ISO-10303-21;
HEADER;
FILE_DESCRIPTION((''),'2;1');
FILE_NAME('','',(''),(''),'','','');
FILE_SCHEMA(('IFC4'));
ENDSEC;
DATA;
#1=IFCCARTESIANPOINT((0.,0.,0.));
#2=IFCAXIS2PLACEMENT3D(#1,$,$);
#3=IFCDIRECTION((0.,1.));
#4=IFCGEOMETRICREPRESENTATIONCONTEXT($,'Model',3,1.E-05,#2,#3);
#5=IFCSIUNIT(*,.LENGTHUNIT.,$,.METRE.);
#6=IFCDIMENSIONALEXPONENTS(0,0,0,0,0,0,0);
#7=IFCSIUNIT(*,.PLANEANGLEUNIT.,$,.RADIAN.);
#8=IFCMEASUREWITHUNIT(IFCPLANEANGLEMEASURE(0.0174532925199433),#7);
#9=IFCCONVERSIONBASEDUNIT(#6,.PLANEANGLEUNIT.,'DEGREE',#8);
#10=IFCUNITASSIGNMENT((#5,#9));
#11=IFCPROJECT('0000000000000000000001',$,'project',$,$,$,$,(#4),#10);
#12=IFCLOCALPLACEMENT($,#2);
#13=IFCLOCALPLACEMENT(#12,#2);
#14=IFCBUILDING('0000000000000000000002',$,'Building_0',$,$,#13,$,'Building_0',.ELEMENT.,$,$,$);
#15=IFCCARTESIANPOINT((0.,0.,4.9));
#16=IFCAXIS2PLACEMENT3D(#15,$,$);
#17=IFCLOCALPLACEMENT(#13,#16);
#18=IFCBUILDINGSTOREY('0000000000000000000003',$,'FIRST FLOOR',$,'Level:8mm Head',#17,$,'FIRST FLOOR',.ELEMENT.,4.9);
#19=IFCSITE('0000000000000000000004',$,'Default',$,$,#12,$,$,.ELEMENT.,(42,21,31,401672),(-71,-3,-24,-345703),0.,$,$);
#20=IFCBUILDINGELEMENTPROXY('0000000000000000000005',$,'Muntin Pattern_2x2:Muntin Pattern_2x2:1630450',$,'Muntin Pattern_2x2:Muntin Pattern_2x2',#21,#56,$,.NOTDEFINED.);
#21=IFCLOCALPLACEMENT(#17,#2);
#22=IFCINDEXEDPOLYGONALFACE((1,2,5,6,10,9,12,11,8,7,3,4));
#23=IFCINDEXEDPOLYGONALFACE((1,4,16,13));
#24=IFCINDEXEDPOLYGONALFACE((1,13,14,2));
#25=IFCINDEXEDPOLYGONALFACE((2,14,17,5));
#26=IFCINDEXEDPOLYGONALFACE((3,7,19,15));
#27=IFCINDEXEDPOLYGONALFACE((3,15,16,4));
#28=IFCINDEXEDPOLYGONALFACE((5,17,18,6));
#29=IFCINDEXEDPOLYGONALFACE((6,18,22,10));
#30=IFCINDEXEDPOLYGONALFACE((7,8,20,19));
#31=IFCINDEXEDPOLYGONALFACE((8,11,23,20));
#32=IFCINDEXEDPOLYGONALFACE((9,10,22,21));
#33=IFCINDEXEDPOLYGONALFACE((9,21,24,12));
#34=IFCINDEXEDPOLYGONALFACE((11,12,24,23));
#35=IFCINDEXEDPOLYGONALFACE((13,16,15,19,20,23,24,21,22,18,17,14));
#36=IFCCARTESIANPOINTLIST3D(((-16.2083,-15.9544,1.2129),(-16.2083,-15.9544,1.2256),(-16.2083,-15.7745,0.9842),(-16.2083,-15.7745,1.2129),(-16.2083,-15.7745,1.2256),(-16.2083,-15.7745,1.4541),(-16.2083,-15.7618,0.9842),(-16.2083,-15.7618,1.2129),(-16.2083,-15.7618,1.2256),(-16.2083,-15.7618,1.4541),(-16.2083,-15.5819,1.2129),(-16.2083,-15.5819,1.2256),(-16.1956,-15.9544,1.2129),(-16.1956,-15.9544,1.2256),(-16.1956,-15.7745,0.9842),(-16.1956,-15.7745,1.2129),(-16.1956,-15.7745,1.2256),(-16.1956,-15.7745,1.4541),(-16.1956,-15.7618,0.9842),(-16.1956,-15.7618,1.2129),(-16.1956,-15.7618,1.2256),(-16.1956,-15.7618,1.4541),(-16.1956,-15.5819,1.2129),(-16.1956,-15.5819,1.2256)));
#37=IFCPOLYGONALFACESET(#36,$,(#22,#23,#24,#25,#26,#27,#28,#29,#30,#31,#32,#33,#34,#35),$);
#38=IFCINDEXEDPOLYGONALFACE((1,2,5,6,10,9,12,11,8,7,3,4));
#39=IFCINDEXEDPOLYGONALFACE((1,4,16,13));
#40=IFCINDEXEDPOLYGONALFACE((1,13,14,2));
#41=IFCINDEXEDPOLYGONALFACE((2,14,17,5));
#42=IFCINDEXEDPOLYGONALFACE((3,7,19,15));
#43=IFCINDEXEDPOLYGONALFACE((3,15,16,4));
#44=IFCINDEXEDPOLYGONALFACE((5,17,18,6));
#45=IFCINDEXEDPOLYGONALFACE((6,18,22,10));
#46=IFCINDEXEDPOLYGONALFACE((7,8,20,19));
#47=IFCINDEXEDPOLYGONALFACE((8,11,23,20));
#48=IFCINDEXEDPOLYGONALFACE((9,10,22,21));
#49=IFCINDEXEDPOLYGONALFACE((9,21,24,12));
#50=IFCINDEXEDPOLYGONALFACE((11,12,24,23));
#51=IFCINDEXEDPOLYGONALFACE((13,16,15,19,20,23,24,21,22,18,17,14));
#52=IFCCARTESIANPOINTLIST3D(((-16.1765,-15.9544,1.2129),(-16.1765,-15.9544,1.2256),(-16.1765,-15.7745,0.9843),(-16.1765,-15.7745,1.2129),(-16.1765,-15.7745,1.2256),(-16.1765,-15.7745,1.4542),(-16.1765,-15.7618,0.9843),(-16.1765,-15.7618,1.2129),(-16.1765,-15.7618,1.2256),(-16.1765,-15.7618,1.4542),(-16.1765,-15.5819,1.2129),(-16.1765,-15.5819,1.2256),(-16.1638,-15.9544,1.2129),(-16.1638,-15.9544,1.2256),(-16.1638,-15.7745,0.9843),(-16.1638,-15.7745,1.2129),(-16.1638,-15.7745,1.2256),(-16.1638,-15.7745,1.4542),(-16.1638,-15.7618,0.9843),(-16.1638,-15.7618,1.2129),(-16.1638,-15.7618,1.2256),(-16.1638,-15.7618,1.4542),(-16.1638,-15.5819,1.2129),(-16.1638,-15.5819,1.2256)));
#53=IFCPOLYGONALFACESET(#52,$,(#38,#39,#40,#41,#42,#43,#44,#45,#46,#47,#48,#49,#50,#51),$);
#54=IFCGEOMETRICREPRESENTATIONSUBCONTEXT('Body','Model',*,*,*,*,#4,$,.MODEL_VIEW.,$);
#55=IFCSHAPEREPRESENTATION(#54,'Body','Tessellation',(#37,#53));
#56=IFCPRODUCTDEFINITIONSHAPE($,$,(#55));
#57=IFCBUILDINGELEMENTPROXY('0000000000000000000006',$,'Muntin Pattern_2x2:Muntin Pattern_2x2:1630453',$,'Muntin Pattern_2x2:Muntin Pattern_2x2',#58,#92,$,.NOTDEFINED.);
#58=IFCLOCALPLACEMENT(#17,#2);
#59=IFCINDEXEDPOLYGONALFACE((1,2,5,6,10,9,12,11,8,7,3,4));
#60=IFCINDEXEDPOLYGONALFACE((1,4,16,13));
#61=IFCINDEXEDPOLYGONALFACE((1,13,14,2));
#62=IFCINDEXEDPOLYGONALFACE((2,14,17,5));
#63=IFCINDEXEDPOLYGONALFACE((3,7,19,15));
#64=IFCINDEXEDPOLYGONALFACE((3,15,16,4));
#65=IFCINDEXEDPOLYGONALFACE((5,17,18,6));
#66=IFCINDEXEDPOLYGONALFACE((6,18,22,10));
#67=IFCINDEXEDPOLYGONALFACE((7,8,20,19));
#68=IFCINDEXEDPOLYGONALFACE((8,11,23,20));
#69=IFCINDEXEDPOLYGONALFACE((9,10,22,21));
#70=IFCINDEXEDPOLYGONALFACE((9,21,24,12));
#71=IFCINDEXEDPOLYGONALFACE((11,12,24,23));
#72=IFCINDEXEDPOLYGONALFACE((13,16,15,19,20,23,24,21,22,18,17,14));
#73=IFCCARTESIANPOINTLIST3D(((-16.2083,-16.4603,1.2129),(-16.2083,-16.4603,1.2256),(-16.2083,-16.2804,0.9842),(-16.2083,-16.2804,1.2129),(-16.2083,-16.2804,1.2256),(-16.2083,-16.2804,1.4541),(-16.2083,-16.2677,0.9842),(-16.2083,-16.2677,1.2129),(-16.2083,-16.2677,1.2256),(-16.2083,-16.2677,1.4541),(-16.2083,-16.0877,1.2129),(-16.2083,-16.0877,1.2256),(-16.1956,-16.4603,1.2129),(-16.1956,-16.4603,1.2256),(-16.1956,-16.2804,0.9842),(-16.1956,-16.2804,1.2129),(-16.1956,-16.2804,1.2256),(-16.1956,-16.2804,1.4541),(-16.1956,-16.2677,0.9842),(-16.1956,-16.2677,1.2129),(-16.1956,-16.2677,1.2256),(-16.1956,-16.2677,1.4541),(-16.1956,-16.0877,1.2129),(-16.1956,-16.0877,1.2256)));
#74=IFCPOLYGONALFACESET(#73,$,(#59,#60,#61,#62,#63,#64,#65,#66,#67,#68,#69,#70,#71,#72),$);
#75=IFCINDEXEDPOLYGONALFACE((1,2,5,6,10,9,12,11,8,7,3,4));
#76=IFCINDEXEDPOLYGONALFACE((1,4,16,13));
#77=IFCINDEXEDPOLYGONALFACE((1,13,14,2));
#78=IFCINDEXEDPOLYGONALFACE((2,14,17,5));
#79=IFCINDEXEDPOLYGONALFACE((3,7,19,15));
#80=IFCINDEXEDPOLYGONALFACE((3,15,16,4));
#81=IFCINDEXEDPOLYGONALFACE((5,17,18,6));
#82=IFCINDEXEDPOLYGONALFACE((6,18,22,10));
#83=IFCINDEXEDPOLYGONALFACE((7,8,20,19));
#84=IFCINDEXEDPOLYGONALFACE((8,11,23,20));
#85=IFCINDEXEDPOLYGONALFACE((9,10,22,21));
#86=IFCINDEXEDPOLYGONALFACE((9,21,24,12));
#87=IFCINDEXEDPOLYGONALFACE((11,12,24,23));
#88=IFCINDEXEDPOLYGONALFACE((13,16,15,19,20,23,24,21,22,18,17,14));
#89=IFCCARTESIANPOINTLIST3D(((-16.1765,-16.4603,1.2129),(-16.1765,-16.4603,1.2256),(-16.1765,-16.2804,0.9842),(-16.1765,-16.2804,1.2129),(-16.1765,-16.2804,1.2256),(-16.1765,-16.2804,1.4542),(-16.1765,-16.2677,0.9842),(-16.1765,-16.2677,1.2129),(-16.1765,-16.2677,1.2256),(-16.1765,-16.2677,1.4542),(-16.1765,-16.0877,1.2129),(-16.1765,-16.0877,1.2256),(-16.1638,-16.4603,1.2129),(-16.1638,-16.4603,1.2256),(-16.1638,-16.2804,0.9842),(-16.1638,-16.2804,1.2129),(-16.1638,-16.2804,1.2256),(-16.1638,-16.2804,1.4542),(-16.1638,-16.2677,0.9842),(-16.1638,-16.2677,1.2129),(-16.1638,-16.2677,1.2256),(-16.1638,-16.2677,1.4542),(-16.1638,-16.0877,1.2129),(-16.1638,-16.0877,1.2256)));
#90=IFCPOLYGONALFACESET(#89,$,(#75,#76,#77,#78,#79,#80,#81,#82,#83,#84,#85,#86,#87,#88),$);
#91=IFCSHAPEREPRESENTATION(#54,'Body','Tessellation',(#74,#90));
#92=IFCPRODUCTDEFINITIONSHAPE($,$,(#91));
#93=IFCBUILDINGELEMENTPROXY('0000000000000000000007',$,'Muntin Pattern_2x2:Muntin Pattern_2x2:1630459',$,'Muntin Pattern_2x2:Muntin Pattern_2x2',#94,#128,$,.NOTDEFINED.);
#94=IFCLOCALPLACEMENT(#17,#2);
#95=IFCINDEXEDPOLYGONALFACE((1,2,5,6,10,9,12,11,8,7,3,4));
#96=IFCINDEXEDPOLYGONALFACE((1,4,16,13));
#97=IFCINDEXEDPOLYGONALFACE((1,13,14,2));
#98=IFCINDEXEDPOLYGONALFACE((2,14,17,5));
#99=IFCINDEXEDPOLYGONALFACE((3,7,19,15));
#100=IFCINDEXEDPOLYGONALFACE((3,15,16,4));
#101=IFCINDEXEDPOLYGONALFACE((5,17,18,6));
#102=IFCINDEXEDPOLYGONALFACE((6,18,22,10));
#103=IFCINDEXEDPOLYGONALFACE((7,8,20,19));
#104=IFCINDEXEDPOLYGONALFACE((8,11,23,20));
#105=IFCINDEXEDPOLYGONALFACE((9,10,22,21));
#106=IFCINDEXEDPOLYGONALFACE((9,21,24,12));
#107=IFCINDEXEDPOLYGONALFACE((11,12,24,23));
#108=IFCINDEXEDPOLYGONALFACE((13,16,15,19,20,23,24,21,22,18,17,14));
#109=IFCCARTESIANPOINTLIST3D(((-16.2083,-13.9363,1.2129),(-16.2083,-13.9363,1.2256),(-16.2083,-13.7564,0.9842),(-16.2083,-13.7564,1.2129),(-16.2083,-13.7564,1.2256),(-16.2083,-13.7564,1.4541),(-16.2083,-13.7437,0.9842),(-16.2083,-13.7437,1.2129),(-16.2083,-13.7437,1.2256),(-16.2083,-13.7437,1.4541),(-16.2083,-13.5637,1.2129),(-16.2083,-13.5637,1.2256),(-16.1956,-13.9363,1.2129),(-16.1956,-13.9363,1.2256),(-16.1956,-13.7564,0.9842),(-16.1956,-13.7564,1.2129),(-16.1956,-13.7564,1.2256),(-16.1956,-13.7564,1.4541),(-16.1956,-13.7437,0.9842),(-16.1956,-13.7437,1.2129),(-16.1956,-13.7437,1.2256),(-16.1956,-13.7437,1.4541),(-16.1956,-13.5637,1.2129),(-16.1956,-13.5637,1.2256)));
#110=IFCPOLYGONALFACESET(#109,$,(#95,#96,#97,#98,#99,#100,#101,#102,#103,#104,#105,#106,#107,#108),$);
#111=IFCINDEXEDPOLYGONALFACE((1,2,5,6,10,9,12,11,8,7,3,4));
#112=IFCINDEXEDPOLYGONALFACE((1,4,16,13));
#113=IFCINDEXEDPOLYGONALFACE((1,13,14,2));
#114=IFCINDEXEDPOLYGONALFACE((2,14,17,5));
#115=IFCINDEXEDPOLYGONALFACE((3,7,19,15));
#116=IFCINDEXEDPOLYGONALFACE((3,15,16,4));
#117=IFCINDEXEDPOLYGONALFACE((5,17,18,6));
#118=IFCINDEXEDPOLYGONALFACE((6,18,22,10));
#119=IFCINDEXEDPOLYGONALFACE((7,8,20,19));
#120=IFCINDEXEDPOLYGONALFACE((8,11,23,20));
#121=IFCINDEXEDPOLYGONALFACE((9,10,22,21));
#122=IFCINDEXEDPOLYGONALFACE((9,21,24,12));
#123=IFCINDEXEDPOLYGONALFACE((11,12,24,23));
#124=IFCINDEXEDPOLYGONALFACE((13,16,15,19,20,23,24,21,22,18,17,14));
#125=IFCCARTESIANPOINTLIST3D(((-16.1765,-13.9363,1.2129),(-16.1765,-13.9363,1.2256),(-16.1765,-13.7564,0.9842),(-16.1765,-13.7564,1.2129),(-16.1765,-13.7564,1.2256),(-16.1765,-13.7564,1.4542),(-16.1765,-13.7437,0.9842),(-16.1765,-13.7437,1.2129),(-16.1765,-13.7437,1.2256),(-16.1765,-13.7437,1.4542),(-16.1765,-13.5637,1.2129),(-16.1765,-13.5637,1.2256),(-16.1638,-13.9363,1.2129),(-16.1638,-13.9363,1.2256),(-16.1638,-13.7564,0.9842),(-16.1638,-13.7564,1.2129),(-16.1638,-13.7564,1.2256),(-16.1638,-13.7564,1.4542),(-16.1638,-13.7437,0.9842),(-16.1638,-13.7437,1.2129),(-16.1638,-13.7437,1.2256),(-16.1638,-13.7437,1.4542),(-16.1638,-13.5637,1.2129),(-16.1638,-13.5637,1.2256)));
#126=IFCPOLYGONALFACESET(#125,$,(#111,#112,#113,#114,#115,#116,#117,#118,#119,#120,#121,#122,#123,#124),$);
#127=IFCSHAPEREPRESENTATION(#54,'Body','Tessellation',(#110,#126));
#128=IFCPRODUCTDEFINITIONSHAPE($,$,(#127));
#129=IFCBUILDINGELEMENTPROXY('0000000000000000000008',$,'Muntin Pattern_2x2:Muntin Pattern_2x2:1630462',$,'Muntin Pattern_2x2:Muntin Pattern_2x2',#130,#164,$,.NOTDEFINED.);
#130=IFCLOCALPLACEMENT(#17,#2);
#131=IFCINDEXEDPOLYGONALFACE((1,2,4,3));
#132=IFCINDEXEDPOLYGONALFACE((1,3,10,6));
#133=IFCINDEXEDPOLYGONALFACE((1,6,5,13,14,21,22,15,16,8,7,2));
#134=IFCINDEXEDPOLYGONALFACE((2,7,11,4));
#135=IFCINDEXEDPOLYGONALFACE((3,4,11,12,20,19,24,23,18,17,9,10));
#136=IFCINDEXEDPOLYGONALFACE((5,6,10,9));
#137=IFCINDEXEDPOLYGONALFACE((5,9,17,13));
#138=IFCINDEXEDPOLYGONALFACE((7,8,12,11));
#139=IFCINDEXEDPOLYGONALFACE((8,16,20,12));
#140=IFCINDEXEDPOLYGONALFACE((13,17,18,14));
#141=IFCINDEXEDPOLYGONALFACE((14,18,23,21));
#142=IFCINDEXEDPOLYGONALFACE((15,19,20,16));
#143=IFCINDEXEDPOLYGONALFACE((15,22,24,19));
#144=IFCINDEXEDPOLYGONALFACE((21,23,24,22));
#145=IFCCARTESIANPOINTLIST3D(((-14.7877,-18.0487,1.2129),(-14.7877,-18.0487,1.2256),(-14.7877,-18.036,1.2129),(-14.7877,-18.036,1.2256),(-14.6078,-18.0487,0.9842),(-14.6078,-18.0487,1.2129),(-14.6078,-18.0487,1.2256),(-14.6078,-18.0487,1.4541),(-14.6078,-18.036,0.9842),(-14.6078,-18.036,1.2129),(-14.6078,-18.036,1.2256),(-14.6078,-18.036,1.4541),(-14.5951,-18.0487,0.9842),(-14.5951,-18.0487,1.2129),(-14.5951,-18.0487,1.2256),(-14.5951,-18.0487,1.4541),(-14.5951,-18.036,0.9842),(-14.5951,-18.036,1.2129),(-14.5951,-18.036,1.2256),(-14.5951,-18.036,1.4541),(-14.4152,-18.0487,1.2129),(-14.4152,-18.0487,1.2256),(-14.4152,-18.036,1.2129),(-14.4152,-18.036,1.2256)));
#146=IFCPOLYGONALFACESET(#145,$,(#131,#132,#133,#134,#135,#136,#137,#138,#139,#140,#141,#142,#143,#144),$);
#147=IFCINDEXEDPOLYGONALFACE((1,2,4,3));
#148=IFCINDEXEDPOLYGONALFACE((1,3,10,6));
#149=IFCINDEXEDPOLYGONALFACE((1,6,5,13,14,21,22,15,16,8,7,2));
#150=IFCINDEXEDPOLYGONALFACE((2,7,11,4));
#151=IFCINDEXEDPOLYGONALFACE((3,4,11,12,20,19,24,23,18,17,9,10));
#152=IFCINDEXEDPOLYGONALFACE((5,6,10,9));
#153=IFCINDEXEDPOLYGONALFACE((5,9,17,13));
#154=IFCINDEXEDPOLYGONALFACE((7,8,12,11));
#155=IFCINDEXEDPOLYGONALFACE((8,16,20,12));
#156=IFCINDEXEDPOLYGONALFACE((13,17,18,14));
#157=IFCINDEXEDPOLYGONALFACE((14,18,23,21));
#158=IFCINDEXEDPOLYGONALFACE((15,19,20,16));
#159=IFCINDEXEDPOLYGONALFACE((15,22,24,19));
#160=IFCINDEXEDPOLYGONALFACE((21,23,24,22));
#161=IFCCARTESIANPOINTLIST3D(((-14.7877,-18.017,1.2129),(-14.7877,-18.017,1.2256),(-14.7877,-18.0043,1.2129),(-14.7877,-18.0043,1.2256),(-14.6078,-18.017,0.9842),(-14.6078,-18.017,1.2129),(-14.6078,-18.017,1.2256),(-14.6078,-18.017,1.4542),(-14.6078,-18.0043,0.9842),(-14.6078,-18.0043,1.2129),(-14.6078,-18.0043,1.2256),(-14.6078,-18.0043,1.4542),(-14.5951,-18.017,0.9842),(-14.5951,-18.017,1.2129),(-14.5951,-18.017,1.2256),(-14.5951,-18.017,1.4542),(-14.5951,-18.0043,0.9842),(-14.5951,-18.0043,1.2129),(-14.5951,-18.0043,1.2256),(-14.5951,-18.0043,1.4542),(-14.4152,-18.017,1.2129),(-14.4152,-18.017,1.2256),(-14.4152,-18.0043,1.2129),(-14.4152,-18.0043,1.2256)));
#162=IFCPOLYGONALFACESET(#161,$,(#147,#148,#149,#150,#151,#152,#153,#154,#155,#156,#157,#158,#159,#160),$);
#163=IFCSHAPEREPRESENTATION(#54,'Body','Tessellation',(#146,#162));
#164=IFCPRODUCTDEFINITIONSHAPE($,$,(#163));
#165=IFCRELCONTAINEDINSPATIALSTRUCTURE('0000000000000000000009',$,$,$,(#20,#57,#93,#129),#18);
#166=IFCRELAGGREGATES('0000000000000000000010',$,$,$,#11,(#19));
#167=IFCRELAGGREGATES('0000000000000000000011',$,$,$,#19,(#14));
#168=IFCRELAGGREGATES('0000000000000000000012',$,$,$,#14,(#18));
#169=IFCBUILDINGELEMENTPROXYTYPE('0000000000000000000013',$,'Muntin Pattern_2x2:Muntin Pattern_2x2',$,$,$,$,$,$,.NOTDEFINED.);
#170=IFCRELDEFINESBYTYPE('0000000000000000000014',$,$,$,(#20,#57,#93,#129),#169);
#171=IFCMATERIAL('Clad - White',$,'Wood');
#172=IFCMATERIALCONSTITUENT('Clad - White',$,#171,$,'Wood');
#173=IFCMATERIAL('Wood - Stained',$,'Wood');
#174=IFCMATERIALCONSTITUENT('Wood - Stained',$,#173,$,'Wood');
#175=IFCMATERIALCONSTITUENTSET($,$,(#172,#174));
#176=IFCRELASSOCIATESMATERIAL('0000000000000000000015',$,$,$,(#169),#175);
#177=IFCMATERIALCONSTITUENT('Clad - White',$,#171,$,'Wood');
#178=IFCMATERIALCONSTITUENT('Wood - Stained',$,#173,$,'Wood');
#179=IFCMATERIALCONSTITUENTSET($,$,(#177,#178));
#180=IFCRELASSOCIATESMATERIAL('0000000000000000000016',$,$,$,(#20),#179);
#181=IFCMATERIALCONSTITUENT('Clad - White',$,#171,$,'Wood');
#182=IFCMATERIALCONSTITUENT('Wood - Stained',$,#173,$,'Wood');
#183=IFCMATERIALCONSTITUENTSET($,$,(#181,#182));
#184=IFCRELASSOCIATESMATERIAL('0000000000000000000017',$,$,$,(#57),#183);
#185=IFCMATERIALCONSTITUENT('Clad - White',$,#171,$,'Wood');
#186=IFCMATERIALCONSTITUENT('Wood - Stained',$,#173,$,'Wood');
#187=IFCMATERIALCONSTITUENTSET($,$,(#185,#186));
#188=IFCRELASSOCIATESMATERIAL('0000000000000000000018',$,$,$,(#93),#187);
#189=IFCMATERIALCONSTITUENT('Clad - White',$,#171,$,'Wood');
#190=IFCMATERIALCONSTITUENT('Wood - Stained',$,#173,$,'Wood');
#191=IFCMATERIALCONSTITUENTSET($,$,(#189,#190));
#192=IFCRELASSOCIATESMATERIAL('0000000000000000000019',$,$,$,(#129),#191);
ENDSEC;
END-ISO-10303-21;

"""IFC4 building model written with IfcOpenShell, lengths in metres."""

from ifc_helpers import new_model, entity, si_unit, converted_unit, direction, frame, origin, place, context, subcontext, project, spatial, indexed_curve, outline, extrude, source, transform, mapped, material, constituent, constituent_set, type_object, type_shapes, element, save


model = new_model("IFC4")

# Units and contexts
model_context = context("Model", 3, precision=1e-05, world=origin(), true_north=direction((0.0, 1.0)))
body_context = subcontext(model_context, "Body", "Model", "MODEL_VIEW")
ifc_project = project(units=[si_unit("LENGTHUNIT", "METRE"), converted_unit("PLANEANGLEUNIT", "DEGREE", entity("IfcPlaneAngleMeasure", 0.0174532925199433), si_unit("PLANEANGLEUNIT", "RADIAN"), dimensions=[0, 0, 0, 0, 0, 0, 0])], contexts=[model_context])

# Site, building, storey
site_placement = place(None, origin())
site = spatial("IfcSite", under=ifc_project, at=site_placement, Name="Default", CompositionType="ELEMENT", RefLatitude=(42, 21, 31, 401672), RefLongitude=(-71, -3, -24, -345703), RefElevation=0.0)
building_placement = place(site_placement, origin())
building = spatial("IfcBuilding", under=site, at=building_placement, Name="Building_0", LongName="Building_0", CompositionType="ELEMENT")
storey_placement = place(building_placement, frame((0.0, 0.0, 4.9)))
storey = spatial("IfcBuildingStorey", under=building, at=storey_placement, Name="FIRST FLOOR", ObjectType="Level:8mm Head", LongName="FIRST FLOOR", CompositionType="ELEMENT", Elevation=4.9)

# Shared definitions
ifc_material_1 = material(Name="Clad - White", Category="Wood")

# Building element proxies
ifc_material_2 = material(Name="Wood - Stained", Category="Wood")
ifc_constituent_1 = constituent(ifc_material_1, Name="Clad - White", Category="Wood")
ifc_constituent_2 = constituent(ifc_material_2, Name="Wood - Stained", Category="Wood")
ifc_constituent_set_1 = constituent_set(constituents=[ifc_constituent_1, ifc_constituent_2])
ifc_constituent_3 = constituent(ifc_material_1, Name="Clad - White", Category="Wood")
ifc_constituent_4 = constituent(ifc_material_2, Name="Wood - Stained", Category="Wood")
ifc_constituent_set_2 = constituent_set(constituents=[ifc_constituent_3, ifc_constituent_4])
building_element_proxy_type_1 = type_object("IfcBuildingElementProxyType", Name="Muntin Pattern_2x2:Muntin Pattern_2x2", PredefinedType="NOTDEFINED", material=ifc_constituent_set_2)
shared_shape_1 = source(origin(), body_context, "Body", "SweptSolid", [
    extrude(outline(indexed_curve([(0.0064, -0.0064), (0.2349, -0.0064), (0.2349, 0.0063), (0.0064, 0.0063), (0.0064, 0.1863), (-0.0063, 0.1863), (-0.0063, 0.0063), (-0.235, 0.0063), (-0.235, -0.0064), (-0.0063, -0.0064), (-0.0063, -0.1863), (0.0064, -0.1863), (0.0064, -0.0064)], self_intersect=False)), frame((0.0, -0.0222, 0.2349), z_axis=(0.0, 1.0, 0.0), x_axis=(0.0, 0.0, 1.0)), (0.0, 0.0, 1.0), 0.0127),
    extrude(outline(indexed_curve([(0.0064, -0.0064), (0.235, -0.0064), (0.235, 0.0063), (0.0064, 0.0063), (0.0064, 0.1863), (-0.0063, 0.1863), (-0.0063, 0.0063), (-0.235, 0.0063), (-0.235, -0.0064), (-0.0063, -0.0064), (-0.0063, -0.1863), (0.0064, -0.1863), (0.0064, -0.0064)], self_intersect=False)), frame((0.0, 0.0095, 0.235), z_axis=(0.0, 1.0, 0.0), x_axis=(0.0, 0.0, 1.0)), (0.0, 0.0, 1.0), 0.0127),
])
type_shapes(building_element_proxy_type_1, [shared_shape_1])
proxy_1_placement = place(storey_placement, frame((-16.1861, -15.7681, 0.9843), z_axis=(0.0, 0.0, 1.0), x_axis=(0.0, -1.0, 0.0)))
element("IfcBuildingElementProxy", 1, at=proxy_1_placement, inside=storey, type_object=building_element_proxy_type_1, material=ifc_constituent_set_1, Name="Muntin Pattern_2x2:Muntin Pattern_2x2:1630450", ObjectType="Muntin Pattern_2x2:Muntin Pattern_2x2", PredefinedType="NOTDEFINED", context=body_context, shape_type="MappedRepresentation", body=[
    mapped(shared_shape_1, transform((0.0, 0.0, 0.0), scale=1.0)),
])
ifc_constituent_5 = constituent(ifc_material_1, Name="Clad - White", Category="Wood")
ifc_constituent_6 = constituent(ifc_material_2, Name="Wood - Stained", Category="Wood")
ifc_constituent_set_3 = constituent_set(constituents=[ifc_constituent_5, ifc_constituent_6])
proxy_2_placement = place(storey_placement, frame((-16.1861, -16.274, 0.9842), z_axis=(0.0, 0.0, 1.0), x_axis=(0.0, -1.0, 0.0)))
element("IfcBuildingElementProxy", 2, at=proxy_2_placement, inside=storey, type_object=building_element_proxy_type_1, material=ifc_constituent_set_3, Name="Muntin Pattern_2x2:Muntin Pattern_2x2:1630453", ObjectType="Muntin Pattern_2x2:Muntin Pattern_2x2", PredefinedType="NOTDEFINED", context=body_context, shape_type="MappedRepresentation", body=[
    mapped(shared_shape_1, transform((0.0, 0.0, 0.0), scale=1.0)),
])
ifc_constituent_7 = constituent(ifc_material_1, Name="Clad - White", Category="Wood")
ifc_constituent_8 = constituent(ifc_material_2, Name="Wood - Stained", Category="Wood")
ifc_constituent_set_4 = constituent_set(constituents=[ifc_constituent_7, ifc_constituent_8])
proxy_3_placement = place(storey_placement, frame((-16.1861, -13.75, 0.9842), z_axis=(0.0, 0.0, 1.0), x_axis=(0.0, -1.0, 0.0)))
element("IfcBuildingElementProxy", 3, at=proxy_3_placement, inside=storey, type_object=building_element_proxy_type_1, material=ifc_constituent_set_4, Name="Muntin Pattern_2x2:Muntin Pattern_2x2:1630459", ObjectType="Muntin Pattern_2x2:Muntin Pattern_2x2", PredefinedType="NOTDEFINED", context=body_context, shape_type="MappedRepresentation", body=[
    mapped(shared_shape_1, transform((0.0, 0.0, 0.0), scale=1.0)),
])
ifc_constituent_9 = constituent(ifc_material_1, Name="Clad - White", Category="Wood")
ifc_constituent_10 = constituent(ifc_material_2, Name="Wood - Stained", Category="Wood")
ifc_constituent_set_5 = constituent_set(constituents=[ifc_constituent_9, ifc_constituent_10])
proxy_4_placement = place(storey_placement, frame((-14.6015, -18.0265, 0.9842)))
element("IfcBuildingElementProxy", 4, at=proxy_4_placement, inside=storey, type_object=building_element_proxy_type_1, material=ifc_constituent_set_5, Name="Muntin Pattern_2x2:Muntin Pattern_2x2:1630462", ObjectType="Muntin Pattern_2x2:Muntin Pattern_2x2", PredefinedType="NOTDEFINED", context=body_context, shape_type="MappedRepresentation", body=[
    mapped(shared_shape_1, transform((0.0, 0.0, 0.0), scale=1.0)),
])

save(model, "model.ifc")
